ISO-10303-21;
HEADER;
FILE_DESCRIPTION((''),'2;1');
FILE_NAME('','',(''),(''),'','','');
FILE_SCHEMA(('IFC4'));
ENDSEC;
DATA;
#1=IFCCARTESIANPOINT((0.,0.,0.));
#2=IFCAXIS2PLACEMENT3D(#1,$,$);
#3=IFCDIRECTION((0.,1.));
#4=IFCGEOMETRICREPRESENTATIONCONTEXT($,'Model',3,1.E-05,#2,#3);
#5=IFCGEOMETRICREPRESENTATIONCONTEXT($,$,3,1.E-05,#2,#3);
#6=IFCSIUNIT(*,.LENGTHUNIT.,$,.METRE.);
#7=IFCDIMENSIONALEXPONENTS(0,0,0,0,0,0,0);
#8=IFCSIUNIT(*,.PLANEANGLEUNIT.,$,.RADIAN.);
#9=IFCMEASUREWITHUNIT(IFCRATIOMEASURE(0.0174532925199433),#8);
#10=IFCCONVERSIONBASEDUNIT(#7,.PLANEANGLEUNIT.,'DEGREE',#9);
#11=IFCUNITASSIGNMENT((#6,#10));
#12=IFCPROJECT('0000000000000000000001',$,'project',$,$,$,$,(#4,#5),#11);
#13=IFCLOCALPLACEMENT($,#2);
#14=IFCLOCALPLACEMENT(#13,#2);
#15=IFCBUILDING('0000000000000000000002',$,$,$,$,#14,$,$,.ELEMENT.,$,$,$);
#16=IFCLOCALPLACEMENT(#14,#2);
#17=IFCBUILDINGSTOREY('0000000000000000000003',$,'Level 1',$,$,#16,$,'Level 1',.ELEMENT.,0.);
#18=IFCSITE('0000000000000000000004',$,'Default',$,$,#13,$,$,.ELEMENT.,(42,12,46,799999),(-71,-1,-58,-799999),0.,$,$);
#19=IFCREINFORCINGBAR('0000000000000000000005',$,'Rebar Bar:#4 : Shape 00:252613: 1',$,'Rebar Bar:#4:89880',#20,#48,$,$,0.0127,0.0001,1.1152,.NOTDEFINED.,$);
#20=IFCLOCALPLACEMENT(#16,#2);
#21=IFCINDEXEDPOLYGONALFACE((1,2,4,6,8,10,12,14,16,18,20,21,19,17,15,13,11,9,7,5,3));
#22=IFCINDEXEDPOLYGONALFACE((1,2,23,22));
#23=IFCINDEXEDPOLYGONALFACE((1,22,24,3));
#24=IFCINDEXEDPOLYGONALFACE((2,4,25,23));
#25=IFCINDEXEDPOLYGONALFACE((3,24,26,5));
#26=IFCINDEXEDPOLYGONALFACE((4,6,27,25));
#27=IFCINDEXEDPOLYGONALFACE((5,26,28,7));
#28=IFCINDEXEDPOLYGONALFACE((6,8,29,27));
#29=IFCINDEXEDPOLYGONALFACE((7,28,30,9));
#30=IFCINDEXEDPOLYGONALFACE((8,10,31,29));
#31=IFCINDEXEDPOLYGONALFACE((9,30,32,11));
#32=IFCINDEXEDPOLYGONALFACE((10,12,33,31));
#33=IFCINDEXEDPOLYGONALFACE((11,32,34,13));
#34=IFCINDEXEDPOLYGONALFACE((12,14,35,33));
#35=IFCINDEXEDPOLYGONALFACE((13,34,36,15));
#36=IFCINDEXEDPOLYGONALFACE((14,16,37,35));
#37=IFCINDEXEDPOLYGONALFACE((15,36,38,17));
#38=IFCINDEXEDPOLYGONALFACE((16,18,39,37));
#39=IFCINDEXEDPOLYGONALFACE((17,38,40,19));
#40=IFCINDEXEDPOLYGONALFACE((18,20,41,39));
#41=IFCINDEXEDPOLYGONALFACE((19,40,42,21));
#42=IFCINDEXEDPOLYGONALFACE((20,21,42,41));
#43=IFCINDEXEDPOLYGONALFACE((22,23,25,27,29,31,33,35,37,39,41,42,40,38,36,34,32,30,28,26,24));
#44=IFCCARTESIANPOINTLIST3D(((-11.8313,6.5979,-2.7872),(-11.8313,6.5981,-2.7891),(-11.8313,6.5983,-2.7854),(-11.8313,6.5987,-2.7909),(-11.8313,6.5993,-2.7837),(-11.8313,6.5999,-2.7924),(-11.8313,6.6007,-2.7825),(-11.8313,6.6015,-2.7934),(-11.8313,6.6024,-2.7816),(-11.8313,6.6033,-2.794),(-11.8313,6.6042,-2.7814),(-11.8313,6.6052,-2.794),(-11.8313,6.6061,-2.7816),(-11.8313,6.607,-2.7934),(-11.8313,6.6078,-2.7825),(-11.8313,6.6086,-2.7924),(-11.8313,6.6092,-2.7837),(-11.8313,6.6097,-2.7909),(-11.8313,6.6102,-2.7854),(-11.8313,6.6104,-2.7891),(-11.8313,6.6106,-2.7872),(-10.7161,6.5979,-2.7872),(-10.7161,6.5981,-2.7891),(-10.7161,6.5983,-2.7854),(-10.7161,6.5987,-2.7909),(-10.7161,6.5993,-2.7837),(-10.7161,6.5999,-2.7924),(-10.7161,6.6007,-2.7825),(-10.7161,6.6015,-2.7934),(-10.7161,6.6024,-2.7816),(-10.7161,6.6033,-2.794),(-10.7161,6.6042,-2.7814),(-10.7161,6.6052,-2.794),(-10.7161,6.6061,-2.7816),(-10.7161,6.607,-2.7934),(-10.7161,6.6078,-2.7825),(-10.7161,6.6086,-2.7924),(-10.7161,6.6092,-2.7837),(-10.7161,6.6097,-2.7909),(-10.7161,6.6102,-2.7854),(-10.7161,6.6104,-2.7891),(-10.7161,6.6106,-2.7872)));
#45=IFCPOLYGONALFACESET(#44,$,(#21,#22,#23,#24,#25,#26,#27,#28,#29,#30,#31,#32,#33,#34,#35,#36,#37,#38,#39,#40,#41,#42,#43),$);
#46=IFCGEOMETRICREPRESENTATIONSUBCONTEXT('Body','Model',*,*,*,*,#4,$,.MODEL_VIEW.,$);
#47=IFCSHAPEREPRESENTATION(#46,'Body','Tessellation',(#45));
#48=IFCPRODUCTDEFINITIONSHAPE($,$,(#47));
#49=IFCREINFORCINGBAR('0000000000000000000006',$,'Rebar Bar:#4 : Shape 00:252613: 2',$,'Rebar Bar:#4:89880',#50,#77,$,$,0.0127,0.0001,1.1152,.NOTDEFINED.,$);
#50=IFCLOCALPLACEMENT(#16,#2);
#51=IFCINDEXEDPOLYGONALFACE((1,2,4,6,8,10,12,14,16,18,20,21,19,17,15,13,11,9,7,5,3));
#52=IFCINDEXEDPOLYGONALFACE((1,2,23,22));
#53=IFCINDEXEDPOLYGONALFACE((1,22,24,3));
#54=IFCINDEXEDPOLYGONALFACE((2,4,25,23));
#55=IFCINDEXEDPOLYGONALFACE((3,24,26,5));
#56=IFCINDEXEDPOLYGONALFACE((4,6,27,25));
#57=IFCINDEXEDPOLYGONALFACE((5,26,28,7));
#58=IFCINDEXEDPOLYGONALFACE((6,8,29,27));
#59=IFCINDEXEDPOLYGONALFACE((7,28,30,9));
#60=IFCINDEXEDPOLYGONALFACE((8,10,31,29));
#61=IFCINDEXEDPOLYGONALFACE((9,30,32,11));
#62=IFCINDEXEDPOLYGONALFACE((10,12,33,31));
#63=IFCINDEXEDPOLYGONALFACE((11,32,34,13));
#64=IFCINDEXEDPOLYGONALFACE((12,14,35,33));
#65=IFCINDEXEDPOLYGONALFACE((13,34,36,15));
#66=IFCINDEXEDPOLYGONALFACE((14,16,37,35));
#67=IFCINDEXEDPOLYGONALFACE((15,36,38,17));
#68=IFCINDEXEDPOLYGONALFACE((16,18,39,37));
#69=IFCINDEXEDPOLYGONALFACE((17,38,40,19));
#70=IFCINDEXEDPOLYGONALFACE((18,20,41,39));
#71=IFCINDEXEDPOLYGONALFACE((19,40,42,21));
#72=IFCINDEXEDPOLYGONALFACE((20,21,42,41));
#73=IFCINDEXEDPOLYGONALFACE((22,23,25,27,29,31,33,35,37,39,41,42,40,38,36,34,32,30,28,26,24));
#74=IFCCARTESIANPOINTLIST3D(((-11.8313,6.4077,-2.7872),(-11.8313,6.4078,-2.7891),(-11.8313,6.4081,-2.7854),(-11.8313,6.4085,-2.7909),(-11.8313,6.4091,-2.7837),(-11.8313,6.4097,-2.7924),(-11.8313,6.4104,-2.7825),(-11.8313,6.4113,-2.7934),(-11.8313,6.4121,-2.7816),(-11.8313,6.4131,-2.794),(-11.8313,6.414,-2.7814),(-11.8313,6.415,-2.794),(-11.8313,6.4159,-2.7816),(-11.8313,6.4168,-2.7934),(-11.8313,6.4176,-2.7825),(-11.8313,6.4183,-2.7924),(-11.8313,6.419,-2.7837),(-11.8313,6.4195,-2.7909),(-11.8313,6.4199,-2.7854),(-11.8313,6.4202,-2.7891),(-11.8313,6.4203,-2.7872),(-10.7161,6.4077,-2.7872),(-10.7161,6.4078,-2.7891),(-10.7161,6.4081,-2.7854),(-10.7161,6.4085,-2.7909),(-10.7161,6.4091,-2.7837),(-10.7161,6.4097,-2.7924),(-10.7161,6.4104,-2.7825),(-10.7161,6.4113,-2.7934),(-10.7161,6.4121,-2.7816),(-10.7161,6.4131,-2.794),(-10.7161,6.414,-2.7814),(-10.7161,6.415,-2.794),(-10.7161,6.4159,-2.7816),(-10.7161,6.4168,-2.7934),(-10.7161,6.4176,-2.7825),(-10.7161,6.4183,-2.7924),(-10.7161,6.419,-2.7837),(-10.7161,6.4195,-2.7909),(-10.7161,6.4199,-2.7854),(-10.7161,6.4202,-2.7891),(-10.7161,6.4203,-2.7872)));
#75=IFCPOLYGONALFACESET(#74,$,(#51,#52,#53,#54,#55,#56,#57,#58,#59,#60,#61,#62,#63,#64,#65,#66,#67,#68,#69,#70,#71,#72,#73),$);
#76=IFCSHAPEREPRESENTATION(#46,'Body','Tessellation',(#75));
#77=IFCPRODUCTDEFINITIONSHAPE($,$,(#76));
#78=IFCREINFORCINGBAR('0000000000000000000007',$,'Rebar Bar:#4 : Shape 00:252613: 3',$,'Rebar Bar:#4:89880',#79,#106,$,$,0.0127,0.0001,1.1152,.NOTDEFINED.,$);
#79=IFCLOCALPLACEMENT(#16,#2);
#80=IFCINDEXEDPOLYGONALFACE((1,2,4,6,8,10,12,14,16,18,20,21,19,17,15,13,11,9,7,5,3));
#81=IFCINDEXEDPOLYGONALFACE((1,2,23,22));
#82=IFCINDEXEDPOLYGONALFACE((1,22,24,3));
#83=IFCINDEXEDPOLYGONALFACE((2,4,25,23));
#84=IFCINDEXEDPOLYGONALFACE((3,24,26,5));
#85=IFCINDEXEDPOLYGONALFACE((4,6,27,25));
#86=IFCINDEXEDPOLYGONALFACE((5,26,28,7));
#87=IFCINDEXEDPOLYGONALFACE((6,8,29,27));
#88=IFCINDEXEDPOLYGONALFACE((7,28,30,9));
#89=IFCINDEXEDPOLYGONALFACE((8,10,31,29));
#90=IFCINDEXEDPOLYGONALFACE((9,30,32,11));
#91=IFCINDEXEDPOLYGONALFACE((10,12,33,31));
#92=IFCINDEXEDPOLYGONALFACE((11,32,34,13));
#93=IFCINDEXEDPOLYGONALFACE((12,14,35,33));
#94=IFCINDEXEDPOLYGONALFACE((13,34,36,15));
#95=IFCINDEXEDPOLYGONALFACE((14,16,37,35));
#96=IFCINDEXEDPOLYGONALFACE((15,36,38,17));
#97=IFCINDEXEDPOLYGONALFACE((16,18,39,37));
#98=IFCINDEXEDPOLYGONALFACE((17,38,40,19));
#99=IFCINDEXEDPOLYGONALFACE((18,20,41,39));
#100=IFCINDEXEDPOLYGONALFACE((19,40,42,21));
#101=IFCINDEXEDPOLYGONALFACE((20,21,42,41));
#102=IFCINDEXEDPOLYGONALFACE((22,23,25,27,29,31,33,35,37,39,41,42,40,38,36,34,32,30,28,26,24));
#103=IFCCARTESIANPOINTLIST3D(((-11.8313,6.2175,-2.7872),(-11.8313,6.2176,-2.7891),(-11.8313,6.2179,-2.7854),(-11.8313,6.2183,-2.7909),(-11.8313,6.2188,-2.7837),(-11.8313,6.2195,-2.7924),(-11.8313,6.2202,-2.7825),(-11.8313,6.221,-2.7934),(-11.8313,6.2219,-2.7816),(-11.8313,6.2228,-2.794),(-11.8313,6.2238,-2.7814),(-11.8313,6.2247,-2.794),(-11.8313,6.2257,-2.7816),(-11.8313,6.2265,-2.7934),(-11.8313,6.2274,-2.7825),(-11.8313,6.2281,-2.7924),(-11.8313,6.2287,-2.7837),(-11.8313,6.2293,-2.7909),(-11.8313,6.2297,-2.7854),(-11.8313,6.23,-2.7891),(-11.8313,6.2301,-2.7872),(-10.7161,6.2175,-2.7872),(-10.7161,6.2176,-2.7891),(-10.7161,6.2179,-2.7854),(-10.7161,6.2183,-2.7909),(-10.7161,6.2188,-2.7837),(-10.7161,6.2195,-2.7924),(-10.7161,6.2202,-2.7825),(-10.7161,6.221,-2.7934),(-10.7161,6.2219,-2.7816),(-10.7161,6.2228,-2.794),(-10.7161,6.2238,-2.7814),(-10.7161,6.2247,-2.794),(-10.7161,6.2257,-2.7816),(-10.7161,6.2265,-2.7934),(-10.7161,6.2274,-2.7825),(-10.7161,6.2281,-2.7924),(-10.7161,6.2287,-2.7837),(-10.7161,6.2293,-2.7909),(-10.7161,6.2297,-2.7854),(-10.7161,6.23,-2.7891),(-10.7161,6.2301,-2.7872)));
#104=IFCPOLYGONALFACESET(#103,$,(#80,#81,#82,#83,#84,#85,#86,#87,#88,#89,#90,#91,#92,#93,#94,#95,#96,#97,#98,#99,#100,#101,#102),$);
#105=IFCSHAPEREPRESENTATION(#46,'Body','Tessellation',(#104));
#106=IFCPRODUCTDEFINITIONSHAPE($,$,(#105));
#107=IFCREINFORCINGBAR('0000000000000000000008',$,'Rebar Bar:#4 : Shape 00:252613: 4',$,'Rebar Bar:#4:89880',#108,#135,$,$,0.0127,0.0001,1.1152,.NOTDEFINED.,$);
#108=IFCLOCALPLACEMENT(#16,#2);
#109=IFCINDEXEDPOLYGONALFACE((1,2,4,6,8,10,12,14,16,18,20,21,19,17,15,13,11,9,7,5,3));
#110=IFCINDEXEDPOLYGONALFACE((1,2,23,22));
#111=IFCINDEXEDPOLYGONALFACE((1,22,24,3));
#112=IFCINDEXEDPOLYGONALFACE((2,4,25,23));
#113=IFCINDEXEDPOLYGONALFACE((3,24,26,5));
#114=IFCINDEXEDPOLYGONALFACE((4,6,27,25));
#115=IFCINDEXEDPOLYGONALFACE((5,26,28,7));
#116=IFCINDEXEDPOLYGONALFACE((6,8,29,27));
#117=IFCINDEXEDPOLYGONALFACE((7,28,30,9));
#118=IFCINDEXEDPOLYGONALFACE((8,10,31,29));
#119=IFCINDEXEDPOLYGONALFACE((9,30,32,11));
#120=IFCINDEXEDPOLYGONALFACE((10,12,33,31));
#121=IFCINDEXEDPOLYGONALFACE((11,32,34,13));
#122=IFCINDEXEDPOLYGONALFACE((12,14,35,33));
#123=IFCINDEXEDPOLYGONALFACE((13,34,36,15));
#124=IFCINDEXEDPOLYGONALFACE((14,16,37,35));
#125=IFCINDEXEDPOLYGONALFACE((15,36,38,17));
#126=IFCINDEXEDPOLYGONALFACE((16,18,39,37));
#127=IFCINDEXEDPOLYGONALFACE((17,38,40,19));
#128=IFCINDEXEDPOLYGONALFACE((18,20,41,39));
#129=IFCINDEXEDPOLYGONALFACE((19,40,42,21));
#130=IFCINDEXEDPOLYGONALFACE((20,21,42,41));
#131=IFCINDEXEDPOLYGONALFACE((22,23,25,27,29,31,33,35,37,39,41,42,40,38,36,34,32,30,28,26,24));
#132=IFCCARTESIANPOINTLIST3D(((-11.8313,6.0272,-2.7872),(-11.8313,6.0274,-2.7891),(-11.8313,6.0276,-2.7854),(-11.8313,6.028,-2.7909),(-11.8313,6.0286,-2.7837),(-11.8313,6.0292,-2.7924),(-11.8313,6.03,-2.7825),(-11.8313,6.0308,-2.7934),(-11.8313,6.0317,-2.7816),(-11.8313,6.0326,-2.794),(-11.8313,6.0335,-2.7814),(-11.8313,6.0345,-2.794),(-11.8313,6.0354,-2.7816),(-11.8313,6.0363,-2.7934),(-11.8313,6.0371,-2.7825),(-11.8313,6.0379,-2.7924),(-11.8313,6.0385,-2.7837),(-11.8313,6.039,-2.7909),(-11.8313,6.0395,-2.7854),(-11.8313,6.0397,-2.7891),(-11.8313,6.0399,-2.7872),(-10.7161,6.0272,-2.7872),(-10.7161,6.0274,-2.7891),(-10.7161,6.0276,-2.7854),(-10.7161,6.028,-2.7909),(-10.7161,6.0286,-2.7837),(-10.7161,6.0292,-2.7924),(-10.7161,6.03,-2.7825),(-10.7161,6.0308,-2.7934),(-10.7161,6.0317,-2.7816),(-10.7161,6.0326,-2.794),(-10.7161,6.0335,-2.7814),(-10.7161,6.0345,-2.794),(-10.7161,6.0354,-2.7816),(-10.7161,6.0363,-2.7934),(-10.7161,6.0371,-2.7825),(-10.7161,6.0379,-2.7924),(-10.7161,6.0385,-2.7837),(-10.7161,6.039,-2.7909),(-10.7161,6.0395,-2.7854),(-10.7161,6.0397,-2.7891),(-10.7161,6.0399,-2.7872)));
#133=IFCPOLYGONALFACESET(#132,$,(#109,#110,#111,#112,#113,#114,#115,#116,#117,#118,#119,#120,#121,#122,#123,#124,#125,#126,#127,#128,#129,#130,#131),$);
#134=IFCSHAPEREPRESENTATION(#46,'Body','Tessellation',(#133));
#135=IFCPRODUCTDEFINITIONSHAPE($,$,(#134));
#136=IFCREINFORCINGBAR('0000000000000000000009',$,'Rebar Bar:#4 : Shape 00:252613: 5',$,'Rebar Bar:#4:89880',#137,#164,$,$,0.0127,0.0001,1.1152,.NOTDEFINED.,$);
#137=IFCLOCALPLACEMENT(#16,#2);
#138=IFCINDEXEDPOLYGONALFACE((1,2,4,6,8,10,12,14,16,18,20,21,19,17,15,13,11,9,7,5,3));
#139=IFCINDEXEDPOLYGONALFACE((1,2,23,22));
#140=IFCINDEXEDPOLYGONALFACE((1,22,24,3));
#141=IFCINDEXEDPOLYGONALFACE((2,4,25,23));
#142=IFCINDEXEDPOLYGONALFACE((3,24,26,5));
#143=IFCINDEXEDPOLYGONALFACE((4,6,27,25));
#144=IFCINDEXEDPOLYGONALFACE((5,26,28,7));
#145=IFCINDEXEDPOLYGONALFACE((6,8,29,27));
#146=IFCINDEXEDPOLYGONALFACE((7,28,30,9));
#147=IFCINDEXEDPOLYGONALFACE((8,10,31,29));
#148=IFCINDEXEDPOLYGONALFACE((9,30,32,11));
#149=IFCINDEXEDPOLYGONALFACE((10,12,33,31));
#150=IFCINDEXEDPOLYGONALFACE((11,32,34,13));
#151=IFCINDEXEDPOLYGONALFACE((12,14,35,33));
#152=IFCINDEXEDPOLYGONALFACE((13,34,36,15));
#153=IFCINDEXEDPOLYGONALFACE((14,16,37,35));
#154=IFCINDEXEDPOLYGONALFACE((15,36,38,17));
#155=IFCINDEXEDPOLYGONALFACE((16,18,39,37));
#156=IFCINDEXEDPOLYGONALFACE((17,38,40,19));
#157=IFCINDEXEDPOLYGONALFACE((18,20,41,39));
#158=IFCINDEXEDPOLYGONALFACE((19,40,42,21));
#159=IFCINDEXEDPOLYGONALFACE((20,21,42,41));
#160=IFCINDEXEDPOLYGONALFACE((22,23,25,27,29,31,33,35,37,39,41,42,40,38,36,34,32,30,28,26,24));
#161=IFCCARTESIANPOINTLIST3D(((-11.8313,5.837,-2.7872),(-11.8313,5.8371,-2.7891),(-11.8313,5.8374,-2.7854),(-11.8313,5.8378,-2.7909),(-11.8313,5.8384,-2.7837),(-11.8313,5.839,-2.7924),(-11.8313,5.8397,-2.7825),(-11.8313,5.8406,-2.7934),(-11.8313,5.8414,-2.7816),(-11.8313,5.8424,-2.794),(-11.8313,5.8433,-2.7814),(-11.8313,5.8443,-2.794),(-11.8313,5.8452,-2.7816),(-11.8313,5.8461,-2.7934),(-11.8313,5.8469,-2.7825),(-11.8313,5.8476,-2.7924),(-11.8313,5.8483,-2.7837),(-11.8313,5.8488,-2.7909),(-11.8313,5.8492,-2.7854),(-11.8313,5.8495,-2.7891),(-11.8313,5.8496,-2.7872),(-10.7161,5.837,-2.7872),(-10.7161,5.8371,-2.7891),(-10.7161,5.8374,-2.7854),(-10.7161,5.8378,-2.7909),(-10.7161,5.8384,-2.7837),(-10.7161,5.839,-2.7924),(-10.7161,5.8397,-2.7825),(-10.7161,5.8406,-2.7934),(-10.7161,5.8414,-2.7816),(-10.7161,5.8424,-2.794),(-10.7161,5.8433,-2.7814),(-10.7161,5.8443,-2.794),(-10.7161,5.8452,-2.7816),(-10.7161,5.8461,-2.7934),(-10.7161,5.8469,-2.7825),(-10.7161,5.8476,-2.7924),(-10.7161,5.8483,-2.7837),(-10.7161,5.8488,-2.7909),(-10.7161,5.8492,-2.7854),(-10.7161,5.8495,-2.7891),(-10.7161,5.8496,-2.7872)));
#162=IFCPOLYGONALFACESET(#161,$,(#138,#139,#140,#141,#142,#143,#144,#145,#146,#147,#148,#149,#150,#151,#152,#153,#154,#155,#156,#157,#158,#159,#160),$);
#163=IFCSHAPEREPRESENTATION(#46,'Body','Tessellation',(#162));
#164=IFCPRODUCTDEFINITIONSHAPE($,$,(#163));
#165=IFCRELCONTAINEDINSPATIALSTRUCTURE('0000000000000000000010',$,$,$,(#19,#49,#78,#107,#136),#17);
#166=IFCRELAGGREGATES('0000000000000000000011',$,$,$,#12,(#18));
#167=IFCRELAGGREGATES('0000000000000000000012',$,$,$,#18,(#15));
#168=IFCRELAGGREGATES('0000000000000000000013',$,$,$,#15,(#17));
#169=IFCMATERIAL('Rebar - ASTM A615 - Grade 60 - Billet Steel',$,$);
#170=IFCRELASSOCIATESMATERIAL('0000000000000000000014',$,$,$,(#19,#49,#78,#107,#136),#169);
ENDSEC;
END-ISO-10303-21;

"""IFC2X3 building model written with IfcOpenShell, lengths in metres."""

from ifc_helpers import new_model, entity, si_unit, converted_unit, direction, origin, place, context, subcontext, project, spatial, material, element, save


model = new_model("IFC2X3")

# Units and contexts
model_context = context("Model", 3, precision=1e-05, world=origin(), true_north=direction((0.0, 1.0)))
context_of_model = context(None, 3, precision=1e-05, world=origin(), true_north=direction((0.0, 1.0)))
body_context = subcontext(model_context, "Body", "Model", "MODEL_VIEW")
ifc_project = project(units=[si_unit("LENGTHUNIT", "METRE"), converted_unit("PLANEANGLEUNIT", "DEGREE", entity("IfcRatioMeasure", 0.0174532925199433), si_unit("PLANEANGLEUNIT", "RADIAN"), dimensions=[0, 0, 0, 0, 0, 0, 0])], contexts=[model_context, context_of_model])

# Site, building, storey
site_placement = place(None, origin())
site = spatial("IfcSite", under=ifc_project, at=site_placement, Name="Default", CompositionType="ELEMENT", RefLatitude=(42, 12, 46, 799999), RefLongitude=(-71, -1, -58, -799999), RefElevation=0.0)
building_placement = place(site_placement, origin())
building = spatial("IfcBuilding", under=site, at=building_placement, CompositionType="ELEMENT")
storey_placement = place(building_placement, origin())
storey = spatial("IfcBuildingStorey", under=building, at=storey_placement, Name="Level 1", LongName="Level 1", CompositionType="ELEMENT", Elevation=0.0)

# Reinforcing bars
ifc_material_1 = material(Name="Rebar - ASTM A615 - Grade 60 - Billet Steel")
reinforcing_bar_1_placement = place(storey_placement, origin())
element("IfcReinforcingBar", 1, at=reinforcing_bar_1_placement, inside=storey, material=ifc_material_1, Name="Rebar Bar:#4 : Shape 00:252613: 1", ObjectType="Rebar Bar:#4:89880", BarLength=1.1152, BarRole="NOTDEFINED", CrossSectionArea=0.0001, NominalDiameter=0.0127, context=body_context, shape_type="AdvancedSweptSolid", body=[
    entity("IfcSweptDiskSolid", entity("IfcCompositeCurve", [entity("IfcCompositeCurveSegment", "CONTINUOUS", True, entity("IfcPolyline", [entity("IfcCartesianPoint", [-11.8313, 6.6042, -2.7877]), entity("IfcCartesianPoint", [-10.7161, 6.6042, -2.7877])]))], False), 0.0063, None, 0.0, 1.0),
])
reinforcing_bar_2_placement = place(storey_placement, origin())
element("IfcReinforcingBar", 2, at=reinforcing_bar_2_placement, inside=storey, material=ifc_material_1, Name="Rebar Bar:#4 : Shape 00:252613: 2", ObjectType="Rebar Bar:#4:89880", BarLength=1.1152, BarRole="NOTDEFINED", CrossSectionArea=0.0001, NominalDiameter=0.0127, context=body_context, shape_type="AdvancedSweptSolid", body=[
    entity("IfcSweptDiskSolid", entity("IfcCompositeCurve", [entity("IfcCompositeCurveSegment", "CONTINUOUS", True, entity("IfcPolyline", [entity("IfcCartesianPoint", [-11.8313, 6.414, -2.7877]), entity("IfcCartesianPoint", [-10.7161, 6.414, -2.7877])]))], False), 0.0063, None, 0.0, 1.0),
])
reinforcing_bar_3_placement = place(storey_placement, origin())
element("IfcReinforcingBar", 3, at=reinforcing_bar_3_placement, inside=storey, material=ifc_material_1, Name="Rebar Bar:#4 : Shape 00:252613: 3", ObjectType="Rebar Bar:#4:89880", BarLength=1.1152, BarRole="NOTDEFINED", CrossSectionArea=0.0001, NominalDiameter=0.0127, context=body_context, shape_type="AdvancedSweptSolid", body=[
    entity("IfcSweptDiskSolid", entity("IfcCompositeCurve", [entity("IfcCompositeCurveSegment", "CONTINUOUS", True, entity("IfcPolyline", [entity("IfcCartesianPoint", [-11.8313, 6.2238, -2.7877]), entity("IfcCartesianPoint", [-10.7161, 6.2238, -2.7877])]))], False), 0.0063, None, 0.0, 1.0),
])
reinforcing_bar_4_placement = place(storey_placement, origin())
element("IfcReinforcingBar", 4, at=reinforcing_bar_4_placement, inside=storey, material=ifc_material_1, Name="Rebar Bar:#4 : Shape 00:252613: 4", ObjectType="Rebar Bar:#4:89880", BarLength=1.1152, BarRole="NOTDEFINED", CrossSectionArea=0.0001, NominalDiameter=0.0127, context=body_context, shape_type="AdvancedSweptSolid", body=[
    entity("IfcSweptDiskSolid", entity("IfcCompositeCurve", [entity("IfcCompositeCurveSegment", "CONTINUOUS", True, entity("IfcPolyline", [entity("IfcCartesianPoint", [-11.8313, 6.0335, -2.7877]), entity("IfcCartesianPoint", [-10.7161, 6.0335, -2.7877])]))], False), 0.0063, None, 0.0, 1.0),
])
reinforcing_bar_5_placement = place(storey_placement, origin())
element("IfcReinforcingBar", 5, at=reinforcing_bar_5_placement, inside=storey, material=ifc_material_1, Name="Rebar Bar:#4 : Shape 00:252613: 5", ObjectType="Rebar Bar:#4:89880", BarLength=1.1152, BarRole="NOTDEFINED", CrossSectionArea=0.0001, NominalDiameter=0.0127, context=body_context, shape_type="AdvancedSweptSolid", body=[
    entity("IfcSweptDiskSolid", entity("IfcCompositeCurve", [entity("IfcCompositeCurveSegment", "CONTINUOUS", True, entity("IfcPolyline", [entity("IfcCartesianPoint", [-11.8313, 5.8433, -2.7877]), entity("IfcCartesianPoint", [-10.7161, 5.8433, -2.7877])]))], False), 0.0063, None, 0.0, 1.0),
])

save(model, "model.ifc")
